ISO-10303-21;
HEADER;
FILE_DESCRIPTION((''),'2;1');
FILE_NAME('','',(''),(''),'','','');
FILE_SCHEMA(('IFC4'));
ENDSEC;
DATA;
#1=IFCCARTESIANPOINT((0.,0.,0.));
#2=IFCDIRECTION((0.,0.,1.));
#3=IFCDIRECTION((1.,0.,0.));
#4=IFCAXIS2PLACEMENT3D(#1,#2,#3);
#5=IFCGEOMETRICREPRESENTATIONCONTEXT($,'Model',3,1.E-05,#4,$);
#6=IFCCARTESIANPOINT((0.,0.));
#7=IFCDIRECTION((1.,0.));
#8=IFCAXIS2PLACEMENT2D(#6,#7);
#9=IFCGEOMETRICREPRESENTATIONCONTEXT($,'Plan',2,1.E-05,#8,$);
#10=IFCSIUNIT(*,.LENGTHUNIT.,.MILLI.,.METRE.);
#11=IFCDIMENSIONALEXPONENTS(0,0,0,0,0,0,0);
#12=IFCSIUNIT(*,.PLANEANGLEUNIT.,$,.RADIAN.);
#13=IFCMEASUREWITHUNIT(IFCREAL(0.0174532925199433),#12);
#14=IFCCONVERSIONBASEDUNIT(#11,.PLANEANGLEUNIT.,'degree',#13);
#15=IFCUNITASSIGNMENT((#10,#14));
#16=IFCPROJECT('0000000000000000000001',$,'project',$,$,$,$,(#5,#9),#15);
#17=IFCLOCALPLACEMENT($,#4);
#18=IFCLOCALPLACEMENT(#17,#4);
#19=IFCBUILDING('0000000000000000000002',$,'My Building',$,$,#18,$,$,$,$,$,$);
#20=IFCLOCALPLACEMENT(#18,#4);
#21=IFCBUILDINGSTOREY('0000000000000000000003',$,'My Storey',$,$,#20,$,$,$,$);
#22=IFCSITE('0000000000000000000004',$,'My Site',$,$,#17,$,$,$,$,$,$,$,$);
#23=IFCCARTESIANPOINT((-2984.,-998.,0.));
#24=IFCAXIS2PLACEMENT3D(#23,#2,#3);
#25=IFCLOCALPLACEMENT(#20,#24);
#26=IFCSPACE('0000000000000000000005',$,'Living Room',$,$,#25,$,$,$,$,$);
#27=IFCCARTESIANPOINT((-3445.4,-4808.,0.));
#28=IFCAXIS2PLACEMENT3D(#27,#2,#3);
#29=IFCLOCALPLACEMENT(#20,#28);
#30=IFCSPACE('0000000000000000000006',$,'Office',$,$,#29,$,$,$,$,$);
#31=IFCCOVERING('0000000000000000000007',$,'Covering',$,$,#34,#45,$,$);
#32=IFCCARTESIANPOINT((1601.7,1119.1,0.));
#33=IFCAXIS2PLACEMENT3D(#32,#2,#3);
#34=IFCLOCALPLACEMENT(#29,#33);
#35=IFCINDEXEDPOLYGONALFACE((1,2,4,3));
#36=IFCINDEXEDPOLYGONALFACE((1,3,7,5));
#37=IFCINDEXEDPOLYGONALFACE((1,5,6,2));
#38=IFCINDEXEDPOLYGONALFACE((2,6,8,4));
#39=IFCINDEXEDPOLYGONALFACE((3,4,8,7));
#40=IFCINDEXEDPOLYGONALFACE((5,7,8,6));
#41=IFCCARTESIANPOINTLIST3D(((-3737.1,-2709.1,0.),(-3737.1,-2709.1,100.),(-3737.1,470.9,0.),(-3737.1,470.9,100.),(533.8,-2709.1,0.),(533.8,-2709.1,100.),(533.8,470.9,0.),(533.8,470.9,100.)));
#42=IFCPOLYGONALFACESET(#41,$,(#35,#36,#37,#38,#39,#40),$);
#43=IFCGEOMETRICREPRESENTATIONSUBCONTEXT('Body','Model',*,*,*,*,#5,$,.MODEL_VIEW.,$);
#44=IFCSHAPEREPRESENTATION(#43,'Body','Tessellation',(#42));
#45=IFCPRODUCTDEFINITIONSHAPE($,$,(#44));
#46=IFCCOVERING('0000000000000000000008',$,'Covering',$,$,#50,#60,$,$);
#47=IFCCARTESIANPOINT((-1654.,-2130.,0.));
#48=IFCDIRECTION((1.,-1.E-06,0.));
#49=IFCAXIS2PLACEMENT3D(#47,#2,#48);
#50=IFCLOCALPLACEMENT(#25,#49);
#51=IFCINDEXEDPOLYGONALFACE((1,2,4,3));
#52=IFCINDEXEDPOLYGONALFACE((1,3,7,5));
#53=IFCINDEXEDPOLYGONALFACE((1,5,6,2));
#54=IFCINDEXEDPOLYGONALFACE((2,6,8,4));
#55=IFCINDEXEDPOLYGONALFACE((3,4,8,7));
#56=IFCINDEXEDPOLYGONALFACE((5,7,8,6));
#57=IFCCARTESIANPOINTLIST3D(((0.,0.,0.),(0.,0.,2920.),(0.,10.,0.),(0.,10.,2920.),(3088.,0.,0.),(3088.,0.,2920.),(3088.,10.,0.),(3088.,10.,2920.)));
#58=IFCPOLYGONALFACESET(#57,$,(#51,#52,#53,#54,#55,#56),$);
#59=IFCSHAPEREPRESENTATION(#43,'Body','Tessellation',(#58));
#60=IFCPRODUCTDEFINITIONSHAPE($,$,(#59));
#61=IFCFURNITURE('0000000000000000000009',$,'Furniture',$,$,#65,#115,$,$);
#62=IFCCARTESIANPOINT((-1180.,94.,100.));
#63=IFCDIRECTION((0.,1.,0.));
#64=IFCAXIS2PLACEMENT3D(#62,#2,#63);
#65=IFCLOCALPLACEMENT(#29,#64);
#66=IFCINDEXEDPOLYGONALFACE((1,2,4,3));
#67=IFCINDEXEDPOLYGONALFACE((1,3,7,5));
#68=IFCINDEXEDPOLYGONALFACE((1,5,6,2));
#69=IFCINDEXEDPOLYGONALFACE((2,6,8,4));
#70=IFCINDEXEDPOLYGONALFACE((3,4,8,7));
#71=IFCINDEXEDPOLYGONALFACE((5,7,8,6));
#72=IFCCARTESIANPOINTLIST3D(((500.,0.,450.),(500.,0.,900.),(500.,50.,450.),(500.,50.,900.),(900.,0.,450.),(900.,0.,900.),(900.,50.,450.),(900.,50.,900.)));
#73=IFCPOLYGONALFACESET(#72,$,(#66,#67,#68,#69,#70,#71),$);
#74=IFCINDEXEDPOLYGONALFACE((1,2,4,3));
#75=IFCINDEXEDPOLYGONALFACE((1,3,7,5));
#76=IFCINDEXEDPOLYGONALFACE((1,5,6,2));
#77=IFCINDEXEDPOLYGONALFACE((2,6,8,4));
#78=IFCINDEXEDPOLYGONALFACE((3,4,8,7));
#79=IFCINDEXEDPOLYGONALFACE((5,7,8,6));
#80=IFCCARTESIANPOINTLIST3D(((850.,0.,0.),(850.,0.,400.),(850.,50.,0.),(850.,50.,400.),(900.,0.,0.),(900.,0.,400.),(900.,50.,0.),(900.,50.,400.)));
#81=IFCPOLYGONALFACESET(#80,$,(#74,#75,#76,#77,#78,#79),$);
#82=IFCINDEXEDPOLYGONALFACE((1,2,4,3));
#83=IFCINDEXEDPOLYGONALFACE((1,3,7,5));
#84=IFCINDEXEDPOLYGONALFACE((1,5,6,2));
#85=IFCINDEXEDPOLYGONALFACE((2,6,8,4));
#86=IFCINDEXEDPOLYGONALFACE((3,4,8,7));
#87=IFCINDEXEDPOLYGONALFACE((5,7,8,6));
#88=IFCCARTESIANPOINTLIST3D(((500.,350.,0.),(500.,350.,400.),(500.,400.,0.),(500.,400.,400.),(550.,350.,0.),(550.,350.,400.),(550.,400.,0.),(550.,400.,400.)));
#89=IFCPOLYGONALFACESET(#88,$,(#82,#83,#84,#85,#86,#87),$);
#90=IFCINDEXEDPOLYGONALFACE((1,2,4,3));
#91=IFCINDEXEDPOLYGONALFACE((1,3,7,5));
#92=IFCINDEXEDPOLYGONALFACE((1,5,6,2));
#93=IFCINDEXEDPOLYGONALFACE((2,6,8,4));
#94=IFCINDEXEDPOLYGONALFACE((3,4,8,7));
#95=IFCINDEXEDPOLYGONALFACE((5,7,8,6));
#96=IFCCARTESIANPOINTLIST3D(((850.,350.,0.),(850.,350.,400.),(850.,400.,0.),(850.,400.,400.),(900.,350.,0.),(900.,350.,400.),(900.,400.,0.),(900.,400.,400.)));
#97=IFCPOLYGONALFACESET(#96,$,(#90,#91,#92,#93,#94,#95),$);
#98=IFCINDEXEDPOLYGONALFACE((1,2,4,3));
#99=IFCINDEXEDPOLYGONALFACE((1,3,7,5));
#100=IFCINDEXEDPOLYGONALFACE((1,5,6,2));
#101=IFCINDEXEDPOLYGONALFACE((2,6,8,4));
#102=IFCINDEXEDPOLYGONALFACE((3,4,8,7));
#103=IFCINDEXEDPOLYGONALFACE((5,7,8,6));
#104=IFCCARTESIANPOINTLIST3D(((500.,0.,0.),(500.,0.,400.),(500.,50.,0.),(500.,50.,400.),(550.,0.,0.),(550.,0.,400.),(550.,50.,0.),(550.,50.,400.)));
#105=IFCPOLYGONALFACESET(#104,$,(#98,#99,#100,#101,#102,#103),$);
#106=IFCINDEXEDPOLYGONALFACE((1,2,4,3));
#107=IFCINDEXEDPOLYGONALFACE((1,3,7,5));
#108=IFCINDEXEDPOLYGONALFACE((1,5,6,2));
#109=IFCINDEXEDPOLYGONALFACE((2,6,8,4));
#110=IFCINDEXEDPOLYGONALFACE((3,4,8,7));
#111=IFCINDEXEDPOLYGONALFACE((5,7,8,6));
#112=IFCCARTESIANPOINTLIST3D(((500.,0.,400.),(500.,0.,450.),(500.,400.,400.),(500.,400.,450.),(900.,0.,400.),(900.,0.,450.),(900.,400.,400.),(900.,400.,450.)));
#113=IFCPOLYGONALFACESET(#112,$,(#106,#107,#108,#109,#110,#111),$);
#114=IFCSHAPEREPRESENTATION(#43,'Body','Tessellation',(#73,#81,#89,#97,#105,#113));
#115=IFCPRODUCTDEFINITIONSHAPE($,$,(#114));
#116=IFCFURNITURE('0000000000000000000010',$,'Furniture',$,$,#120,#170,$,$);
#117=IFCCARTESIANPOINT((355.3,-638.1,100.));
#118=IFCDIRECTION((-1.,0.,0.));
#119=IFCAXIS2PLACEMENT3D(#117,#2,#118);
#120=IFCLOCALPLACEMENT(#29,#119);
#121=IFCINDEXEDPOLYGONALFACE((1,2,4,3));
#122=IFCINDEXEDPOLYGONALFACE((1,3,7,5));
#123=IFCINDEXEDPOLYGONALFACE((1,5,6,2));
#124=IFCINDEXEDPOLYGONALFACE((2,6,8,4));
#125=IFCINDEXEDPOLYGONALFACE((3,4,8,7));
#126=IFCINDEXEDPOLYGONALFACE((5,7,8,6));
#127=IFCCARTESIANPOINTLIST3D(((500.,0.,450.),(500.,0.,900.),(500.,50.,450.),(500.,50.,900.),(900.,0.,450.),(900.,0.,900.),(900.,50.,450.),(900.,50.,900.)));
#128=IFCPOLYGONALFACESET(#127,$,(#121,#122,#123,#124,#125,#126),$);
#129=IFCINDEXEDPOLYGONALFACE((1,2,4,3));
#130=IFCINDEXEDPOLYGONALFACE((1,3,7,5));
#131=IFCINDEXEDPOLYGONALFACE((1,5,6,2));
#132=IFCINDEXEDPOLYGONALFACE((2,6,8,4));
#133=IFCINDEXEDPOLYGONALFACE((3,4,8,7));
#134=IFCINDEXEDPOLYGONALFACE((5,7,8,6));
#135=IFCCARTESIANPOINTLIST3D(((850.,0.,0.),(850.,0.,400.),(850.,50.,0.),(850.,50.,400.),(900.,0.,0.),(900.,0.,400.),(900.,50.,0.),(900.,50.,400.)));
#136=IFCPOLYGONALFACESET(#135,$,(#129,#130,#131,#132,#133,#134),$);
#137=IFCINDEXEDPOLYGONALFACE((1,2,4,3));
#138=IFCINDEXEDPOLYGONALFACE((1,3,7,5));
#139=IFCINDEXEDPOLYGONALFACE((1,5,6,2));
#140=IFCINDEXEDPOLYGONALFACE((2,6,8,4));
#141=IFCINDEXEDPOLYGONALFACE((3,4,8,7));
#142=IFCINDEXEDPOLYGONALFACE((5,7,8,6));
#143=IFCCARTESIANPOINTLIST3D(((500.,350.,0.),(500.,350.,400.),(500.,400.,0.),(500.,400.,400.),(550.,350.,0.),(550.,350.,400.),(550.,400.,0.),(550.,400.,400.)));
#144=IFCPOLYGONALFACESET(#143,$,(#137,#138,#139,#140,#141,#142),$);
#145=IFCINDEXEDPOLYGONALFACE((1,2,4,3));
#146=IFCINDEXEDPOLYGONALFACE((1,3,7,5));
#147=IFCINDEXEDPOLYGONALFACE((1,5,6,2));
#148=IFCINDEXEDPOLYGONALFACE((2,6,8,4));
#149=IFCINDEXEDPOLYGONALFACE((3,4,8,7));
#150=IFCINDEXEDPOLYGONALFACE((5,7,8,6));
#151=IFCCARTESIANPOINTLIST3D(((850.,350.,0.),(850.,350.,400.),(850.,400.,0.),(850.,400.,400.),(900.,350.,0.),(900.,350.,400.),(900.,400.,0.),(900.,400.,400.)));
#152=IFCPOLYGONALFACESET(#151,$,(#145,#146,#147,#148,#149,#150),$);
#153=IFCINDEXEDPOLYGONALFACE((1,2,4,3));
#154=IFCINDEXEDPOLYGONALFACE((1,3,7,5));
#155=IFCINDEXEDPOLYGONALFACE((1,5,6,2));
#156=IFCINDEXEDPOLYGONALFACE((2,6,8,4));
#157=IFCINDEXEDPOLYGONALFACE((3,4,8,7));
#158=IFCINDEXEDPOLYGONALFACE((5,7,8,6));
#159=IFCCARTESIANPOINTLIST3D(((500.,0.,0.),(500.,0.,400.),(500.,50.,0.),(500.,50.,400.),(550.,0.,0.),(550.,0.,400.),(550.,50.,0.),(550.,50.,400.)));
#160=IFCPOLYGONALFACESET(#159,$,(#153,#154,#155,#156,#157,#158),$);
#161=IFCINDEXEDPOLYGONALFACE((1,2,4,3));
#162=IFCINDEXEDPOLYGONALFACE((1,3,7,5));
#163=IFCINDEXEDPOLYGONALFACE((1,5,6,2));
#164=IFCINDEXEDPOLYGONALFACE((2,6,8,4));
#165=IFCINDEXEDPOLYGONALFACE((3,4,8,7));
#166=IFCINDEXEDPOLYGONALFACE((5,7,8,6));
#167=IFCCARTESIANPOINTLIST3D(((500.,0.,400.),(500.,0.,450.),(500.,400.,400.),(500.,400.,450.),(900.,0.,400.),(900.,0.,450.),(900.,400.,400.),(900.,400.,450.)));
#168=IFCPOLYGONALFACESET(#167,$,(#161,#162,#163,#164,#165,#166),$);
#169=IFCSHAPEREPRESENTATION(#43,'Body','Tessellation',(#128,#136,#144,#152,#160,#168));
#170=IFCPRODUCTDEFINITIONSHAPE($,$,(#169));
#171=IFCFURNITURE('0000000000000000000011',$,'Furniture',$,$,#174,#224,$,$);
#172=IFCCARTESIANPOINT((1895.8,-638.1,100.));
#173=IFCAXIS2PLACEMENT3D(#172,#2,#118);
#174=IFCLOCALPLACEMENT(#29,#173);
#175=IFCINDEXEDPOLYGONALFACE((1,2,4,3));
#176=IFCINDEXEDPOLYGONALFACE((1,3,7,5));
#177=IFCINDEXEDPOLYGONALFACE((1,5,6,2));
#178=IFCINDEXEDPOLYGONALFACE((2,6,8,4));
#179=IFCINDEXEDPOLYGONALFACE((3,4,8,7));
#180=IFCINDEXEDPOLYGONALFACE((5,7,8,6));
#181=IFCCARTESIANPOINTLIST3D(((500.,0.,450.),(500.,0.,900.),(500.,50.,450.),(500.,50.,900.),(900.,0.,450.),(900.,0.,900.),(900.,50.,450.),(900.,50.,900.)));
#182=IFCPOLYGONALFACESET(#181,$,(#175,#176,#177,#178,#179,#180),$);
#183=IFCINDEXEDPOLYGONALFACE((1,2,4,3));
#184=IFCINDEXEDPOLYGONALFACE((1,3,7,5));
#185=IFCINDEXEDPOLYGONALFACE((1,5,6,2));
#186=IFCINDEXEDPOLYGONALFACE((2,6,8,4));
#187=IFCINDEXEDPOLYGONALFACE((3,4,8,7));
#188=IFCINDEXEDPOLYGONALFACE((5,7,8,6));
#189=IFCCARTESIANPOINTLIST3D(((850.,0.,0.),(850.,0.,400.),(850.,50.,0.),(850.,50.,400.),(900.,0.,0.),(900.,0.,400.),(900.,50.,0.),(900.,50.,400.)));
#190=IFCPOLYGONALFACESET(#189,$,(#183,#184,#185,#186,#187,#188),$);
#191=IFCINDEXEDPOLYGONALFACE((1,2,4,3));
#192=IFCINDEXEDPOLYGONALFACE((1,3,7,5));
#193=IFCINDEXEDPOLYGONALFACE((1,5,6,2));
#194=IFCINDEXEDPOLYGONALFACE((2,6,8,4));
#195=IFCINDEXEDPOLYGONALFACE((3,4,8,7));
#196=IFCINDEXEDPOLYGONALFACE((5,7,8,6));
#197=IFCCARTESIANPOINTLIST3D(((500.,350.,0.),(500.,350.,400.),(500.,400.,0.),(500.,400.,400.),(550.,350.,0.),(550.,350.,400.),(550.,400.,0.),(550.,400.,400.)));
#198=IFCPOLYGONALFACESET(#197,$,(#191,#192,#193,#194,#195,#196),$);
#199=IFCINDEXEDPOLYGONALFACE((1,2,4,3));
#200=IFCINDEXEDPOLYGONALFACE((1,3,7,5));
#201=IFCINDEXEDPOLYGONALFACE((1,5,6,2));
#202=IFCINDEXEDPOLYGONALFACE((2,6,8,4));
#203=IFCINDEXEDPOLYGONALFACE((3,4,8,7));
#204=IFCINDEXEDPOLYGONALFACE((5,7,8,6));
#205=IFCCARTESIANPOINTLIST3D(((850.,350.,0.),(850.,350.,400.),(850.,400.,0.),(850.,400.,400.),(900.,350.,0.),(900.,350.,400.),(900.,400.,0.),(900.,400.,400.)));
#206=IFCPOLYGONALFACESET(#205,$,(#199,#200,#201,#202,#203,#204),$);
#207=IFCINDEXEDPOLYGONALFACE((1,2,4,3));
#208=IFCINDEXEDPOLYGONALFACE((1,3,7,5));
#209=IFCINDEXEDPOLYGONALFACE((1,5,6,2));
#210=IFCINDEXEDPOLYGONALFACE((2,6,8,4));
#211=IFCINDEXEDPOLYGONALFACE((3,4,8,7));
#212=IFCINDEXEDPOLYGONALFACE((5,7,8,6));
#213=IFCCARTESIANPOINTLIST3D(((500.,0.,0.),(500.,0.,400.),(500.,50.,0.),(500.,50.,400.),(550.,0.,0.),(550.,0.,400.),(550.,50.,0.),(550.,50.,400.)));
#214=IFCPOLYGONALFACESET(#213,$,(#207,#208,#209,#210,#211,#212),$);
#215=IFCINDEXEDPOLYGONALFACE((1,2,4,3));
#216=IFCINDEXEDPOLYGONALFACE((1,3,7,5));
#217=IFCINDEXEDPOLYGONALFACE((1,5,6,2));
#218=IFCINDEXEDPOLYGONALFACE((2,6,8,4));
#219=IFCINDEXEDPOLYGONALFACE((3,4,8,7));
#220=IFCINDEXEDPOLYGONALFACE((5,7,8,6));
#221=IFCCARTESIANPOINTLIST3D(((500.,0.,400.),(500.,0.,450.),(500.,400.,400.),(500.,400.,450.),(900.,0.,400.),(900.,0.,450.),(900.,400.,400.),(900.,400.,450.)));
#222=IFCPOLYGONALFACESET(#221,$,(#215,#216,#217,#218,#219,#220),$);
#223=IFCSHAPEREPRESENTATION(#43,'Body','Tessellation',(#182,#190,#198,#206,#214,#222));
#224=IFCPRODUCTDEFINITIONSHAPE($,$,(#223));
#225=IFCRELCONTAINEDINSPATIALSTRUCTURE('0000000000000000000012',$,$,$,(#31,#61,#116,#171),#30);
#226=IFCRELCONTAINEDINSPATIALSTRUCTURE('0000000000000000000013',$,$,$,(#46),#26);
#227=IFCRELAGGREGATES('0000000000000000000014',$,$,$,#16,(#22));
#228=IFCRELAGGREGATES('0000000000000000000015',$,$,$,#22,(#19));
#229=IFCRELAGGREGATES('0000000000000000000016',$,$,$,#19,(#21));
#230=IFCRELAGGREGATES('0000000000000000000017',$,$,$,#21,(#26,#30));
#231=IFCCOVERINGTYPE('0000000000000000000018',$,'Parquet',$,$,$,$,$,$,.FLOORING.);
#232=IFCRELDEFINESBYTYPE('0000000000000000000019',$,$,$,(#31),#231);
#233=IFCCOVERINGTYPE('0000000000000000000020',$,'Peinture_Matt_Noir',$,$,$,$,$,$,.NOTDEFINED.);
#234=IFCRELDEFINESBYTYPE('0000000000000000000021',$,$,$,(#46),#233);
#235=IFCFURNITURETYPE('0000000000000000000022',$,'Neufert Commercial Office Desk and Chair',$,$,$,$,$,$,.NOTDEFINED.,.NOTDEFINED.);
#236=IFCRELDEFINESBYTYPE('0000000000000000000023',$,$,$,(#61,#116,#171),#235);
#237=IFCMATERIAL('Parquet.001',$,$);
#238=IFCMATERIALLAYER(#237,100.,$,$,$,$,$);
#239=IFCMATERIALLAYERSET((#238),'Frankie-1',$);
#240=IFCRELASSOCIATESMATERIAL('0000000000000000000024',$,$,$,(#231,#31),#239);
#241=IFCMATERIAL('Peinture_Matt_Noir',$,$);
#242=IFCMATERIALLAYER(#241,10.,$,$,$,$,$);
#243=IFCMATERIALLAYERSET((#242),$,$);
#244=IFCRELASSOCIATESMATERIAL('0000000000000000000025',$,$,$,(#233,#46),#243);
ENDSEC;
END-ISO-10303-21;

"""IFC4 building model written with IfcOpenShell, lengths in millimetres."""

from ifc_helpers import new_model, entity, si_unit, converted_unit, frame, origin_with_axes, origin_2d_with_axis, place, context, subcontext, project, spatial, line, indexed_curve, outline, extrude, clip, halfspace, shape, source, transform, mapped, material, layer, layer_set, layer_usage, type_object, type_shapes, element, save


model = new_model("IFC4")

# Units and contexts
model_context = context("Model", 3, precision=1e-05, world=origin_with_axes())
plan_context = context("Plan", 2, precision=1e-05, world=origin_2d_with_axis())
body_context_1 = subcontext(model_context, "Body", "Model", "MODEL_VIEW")
body_context_2 = subcontext(plan_context, "Body", "Plan", "PLAN_VIEW")
ifc_project = project(units=[si_unit("LENGTHUNIT", "METRE", prefix="MILLI"), converted_unit("PLANEANGLEUNIT", "degree", entity("IfcReal", 0.0174532925199433), si_unit("PLANEANGLEUNIT", "RADIAN"), dimensions=[0, 0, 0, 0, 0, 0, 0])], contexts=[model_context, plan_context])

# Site, building, storey
site_placement = place(None, origin_with_axes())
site = spatial("IfcSite", under=ifc_project, at=site_placement, Name="My Site")
building_placement = place(site_placement, origin_with_axes())
building = spatial("IfcBuilding", under=site, at=building_placement, Name="My Building")
storey_placement = place(building_placement, origin_with_axes())
storey = spatial("IfcBuildingStorey", under=building, at=storey_placement, Name="My Storey")

# Shared definitions
space_1_placement = place(storey_placement, frame((-2984.0, -998.0, 0.0), z_axis=(0.0, 0.0, 1.0), x_axis=(1.0, 0.0, 0.0)))
space_1 = spatial("IfcSpace", under=storey, at=space_1_placement, Name="Living Room")

# Shared definitions
space_2_placement = place(storey_placement, frame((-3445.4, -4808.0, 0.0), z_axis=(0.0, 0.0, 1.0), x_axis=(1.0, 0.0, 0.0)))
space_2 = spatial("IfcSpace", under=storey, at=space_2_placement, Name="Office")

# Coverings
ifc_material_1 = material(Name="Parquet.001")
ifc_layer_1 = layer(ifc_material_1, 100.0)
ifc_layer_set_1 = layer_set([ifc_layer_1], Name="Frankie-1")
ifc_layer_usage_1 = layer_usage(ifc_layer_set_1, "AXIS3", "POSITIVE", 0.0)
covering_type_1 = type_object("IfcCoveringType", Name="Parquet", PredefinedType="FLOORING", material=ifc_layer_set_1)
covering_1_placement = place(space_2_placement, frame((1601.7, 1119.1, 0.0), z_axis=(0.0, 0.0, 1.0), x_axis=(1.0, 0.0, 0.0)))
element("IfcCovering", 1, at=covering_1_placement, inside=space_2, type_object=covering_type_1, material=ifc_layer_usage_1, Name="Covering", context=body_context_1, shape_type="SweptSolid", body=[
    extrude(outline(indexed_curve([(533.8, -2709.1), (533.8, 470.9), (-3737.1, 470.9), (-3737.1, -2709.1)], segments=[line(4, 1), line(1, 2), line(2, 3), line(3, 4)], self_intersect=False)), None, (0.0, 0.0, 1.0), 100.0),
])
ifc_material_2 = material(Name="Peinture_Matt_Noir")
ifc_layer_2 = layer(ifc_material_2, 10.0)
ifc_layer_set_2 = layer_set([ifc_layer_2])
covering_type_2 = type_object("IfcCoveringType", Name="Peinture_Matt_Noir", PredefinedType="NOTDEFINED", material=ifc_layer_set_2)
ifc_layer_usage_2 = layer_usage(ifc_layer_set_2, "AXIS2", "POSITIVE", 0.0)
covering_2_placement = place(space_1_placement, frame((-1654.0, -2130.0, 0.0), z_axis=(0.0, 0.0, 1.0), x_axis=(1.0, -0.000001, 0.0)))
element("IfcCovering", 2, at=covering_2_placement, inside=space_1, type_object=covering_type_2, material=ifc_layer_usage_2, Name="Covering", context=body_context_1, shape_type="Clipping", body=[
    clip(extrude(outline(indexed_curve([(0.0, 0.0), (0.0, 10.0), (3088.0, 10.0), (3088.0, 0.0), (0.0, 0.0)], self_intersect=False)), origin_with_axes(), (0.0, 0.0, 1.0), 2920.0), halfspace(frame((0.0, 0.0, 2920.0), z_axis=(0.0, 0.0, 1.0), x_axis=(-1.0, 0.0, 0.0)), False)),
])

# Furniture
furniture_type_1 = type_object("IfcFurnitureType", Name="Neufert Commercial Office Desk and Chair", AssemblyPlace="NOTDEFINED", PredefinedType="NOTDEFINED")
shared_shape_1 = source(origin_with_axes(), body_context_1, "Body", "SweptSolid", [
    extrude(outline(indexed_curve([(-200.0, 0.0), (200.0, 0.0), (200.0, 50.0), (-200.0, 50.0)], segments=[line(4, 1), line(1, 2), line(2, 3), line(3, 4)], self_intersect=False)), frame((700.0, 0.0, 900.0), z_axis=(0.0, 0.0, 1.0), x_axis=(1.0, 0.0, 0.0)), (0.0, 0.0, -1.0), 450.0),
    extrude(outline(indexed_curve([(200.0, 0.0), (150.0, 0.0), (150.0, 50.0), (200.0, 50.0)], segments=[line(1, 2, 3, 4, 1)])), frame((700.0, 0.0, 0.0), z_axis=(0.0, 0.0, 1.0), x_axis=(1.0, 0.0, 0.0)), (0.0, 0.0, 1.0), 400.0),
    extrude(outline(indexed_curve([(-200.0, 400.0), (-150.0, 400.0), (-150.0, 350.0), (-200.0, 350.0)], segments=[line(1, 2, 3, 4, 1)])), frame((700.0, 0.0, 0.0), z_axis=(0.0, 0.0, 1.0), x_axis=(1.0, 0.0, 0.0)), (0.0, 0.0, 1.0), 400.0),
    extrude(outline(indexed_curve([(200.0, 400.0), (150.0, 400.0), (150.0, 350.0), (200.0, 350.0)], segments=[line(1, 2, 3, 4, 1)])), frame((700.0, 0.0, 0.0), z_axis=(0.0, 0.0, 1.0), x_axis=(1.0, 0.0, 0.0)), (0.0, 0.0, 1.0), 400.0),
    extrude(outline(indexed_curve([(-200.0, 0.0), (-150.0, 0.0), (-150.0, 50.0), (-200.0, 50.0)], segments=[line(1, 2, 3, 4, 1)])), frame((700.0, 0.0, 0.0), z_axis=(0.0, 0.0, 1.0), x_axis=(1.0, 0.0, 0.0)), (0.0, 0.0, 1.0), 400.0),
    extrude(outline(indexed_curve([(-200.0, 0.0), (200.0, 0.0), (200.0, 400.0), (-200.0, 400.0)], segments=[line(1, 2, 3, 4, 1)])), frame((700.0, 0.0, 450.0), z_axis=(0.0, 0.0, 1.0), x_axis=(1.0, 0.0, 0.0)), (0.0, 0.0, -1.0), 50.0),
])
shared_shape_2 = source(origin_with_axes(), body_context_2, "Body", "Curve2D", [
    entity("IfcIndexedPolyCurve", entity("IfcCartesianPointList2D", [[0.0, 450.0], [1400.0, 450.0], [1400.0, 1150.0], [0.0, 1150.0]]), [entity("IfcLineIndex", [1, 2, 3, 4, 1])]),
    entity("IfcIndexedPolyCurve", entity("IfcCartesianPointList2D", [[500.0, 400.0], [900.0, 400.0]])),
    entity("IfcIndexedPolyCurve", entity("IfcCartesianPointList2D", [[500.0, 400.0], [500.0, 200.0], [558.6, 58.6], [700.0, 0.0], [841.4, 58.6], [900.0, 200.0], [900.0, 400.0]]), [entity("IfcLineIndex", [1, 2]), entity("IfcArcIndex", [2, 3, 4]), entity("IfcArcIndex", [4, 5, 6]), entity("IfcLineIndex", [6, 7])]),
    entity("IfcIndexedPolyCurve", entity("IfcCartesianPointList2D", [[540.0, 400.0], [540.0, 200.0], [586.9, 86.9], [700.0, 40.0], [813.1, 86.9], [860.0, 200.0], [860.0, 400.0]]), [entity("IfcLineIndex", [1, 2]), entity("IfcArcIndex", [2, 3, 4]), entity("IfcArcIndex", [4, 5, 6]), entity("IfcLineIndex", [6, 7])]),
])
type_shapes(furniture_type_1, [shared_shape_1, shared_shape_2])
for number, where, z_axis, x_axis, name in (
    (3, (-1180.0, 94.0, 100.0), (0.0, 0.0, 1.0), (0.0, 1.0, 0.0), "Furniture"),
    (4, (355.3, -638.1, 100.0), (0.0, 0.0, 1.0), (-1.0, 0.0, 0.0), "Furniture"),
    (5, (1895.8, -638.1, 100.0), (0.0, 0.0, 1.0), (-1.0, 0.0, 0.0), "Furniture"),
):
    element("IfcFurniture", number, at=place(space_2_placement, frame(where, z_axis=z_axis, x_axis=x_axis)), inside=space_2, type_object=furniture_type_1, Name=name, shapes=[
        shape(body_context_1, "Body", "MappedRepresentation", [mapped(shared_shape_1, transform((0.0, 0.0, 0.0), x_axis=(1.0, 0.0, 0.0), y_axis=(0.0, 1.0, 0.0), z_axis=(0.0, 0.0, 1.0), scale=1.0))]),
        shape(body_context_2, "Body", "MappedRepresentation", [mapped(shared_shape_2, transform((0.0, 0.0, 0.0), x_axis=(1.0, 0.0, 0.0), y_axis=(0.0, 1.0, 0.0), z_axis=(0.0, 0.0, 1.0), scale=1.0))]),
    ])

save(model, "model.ifc")
